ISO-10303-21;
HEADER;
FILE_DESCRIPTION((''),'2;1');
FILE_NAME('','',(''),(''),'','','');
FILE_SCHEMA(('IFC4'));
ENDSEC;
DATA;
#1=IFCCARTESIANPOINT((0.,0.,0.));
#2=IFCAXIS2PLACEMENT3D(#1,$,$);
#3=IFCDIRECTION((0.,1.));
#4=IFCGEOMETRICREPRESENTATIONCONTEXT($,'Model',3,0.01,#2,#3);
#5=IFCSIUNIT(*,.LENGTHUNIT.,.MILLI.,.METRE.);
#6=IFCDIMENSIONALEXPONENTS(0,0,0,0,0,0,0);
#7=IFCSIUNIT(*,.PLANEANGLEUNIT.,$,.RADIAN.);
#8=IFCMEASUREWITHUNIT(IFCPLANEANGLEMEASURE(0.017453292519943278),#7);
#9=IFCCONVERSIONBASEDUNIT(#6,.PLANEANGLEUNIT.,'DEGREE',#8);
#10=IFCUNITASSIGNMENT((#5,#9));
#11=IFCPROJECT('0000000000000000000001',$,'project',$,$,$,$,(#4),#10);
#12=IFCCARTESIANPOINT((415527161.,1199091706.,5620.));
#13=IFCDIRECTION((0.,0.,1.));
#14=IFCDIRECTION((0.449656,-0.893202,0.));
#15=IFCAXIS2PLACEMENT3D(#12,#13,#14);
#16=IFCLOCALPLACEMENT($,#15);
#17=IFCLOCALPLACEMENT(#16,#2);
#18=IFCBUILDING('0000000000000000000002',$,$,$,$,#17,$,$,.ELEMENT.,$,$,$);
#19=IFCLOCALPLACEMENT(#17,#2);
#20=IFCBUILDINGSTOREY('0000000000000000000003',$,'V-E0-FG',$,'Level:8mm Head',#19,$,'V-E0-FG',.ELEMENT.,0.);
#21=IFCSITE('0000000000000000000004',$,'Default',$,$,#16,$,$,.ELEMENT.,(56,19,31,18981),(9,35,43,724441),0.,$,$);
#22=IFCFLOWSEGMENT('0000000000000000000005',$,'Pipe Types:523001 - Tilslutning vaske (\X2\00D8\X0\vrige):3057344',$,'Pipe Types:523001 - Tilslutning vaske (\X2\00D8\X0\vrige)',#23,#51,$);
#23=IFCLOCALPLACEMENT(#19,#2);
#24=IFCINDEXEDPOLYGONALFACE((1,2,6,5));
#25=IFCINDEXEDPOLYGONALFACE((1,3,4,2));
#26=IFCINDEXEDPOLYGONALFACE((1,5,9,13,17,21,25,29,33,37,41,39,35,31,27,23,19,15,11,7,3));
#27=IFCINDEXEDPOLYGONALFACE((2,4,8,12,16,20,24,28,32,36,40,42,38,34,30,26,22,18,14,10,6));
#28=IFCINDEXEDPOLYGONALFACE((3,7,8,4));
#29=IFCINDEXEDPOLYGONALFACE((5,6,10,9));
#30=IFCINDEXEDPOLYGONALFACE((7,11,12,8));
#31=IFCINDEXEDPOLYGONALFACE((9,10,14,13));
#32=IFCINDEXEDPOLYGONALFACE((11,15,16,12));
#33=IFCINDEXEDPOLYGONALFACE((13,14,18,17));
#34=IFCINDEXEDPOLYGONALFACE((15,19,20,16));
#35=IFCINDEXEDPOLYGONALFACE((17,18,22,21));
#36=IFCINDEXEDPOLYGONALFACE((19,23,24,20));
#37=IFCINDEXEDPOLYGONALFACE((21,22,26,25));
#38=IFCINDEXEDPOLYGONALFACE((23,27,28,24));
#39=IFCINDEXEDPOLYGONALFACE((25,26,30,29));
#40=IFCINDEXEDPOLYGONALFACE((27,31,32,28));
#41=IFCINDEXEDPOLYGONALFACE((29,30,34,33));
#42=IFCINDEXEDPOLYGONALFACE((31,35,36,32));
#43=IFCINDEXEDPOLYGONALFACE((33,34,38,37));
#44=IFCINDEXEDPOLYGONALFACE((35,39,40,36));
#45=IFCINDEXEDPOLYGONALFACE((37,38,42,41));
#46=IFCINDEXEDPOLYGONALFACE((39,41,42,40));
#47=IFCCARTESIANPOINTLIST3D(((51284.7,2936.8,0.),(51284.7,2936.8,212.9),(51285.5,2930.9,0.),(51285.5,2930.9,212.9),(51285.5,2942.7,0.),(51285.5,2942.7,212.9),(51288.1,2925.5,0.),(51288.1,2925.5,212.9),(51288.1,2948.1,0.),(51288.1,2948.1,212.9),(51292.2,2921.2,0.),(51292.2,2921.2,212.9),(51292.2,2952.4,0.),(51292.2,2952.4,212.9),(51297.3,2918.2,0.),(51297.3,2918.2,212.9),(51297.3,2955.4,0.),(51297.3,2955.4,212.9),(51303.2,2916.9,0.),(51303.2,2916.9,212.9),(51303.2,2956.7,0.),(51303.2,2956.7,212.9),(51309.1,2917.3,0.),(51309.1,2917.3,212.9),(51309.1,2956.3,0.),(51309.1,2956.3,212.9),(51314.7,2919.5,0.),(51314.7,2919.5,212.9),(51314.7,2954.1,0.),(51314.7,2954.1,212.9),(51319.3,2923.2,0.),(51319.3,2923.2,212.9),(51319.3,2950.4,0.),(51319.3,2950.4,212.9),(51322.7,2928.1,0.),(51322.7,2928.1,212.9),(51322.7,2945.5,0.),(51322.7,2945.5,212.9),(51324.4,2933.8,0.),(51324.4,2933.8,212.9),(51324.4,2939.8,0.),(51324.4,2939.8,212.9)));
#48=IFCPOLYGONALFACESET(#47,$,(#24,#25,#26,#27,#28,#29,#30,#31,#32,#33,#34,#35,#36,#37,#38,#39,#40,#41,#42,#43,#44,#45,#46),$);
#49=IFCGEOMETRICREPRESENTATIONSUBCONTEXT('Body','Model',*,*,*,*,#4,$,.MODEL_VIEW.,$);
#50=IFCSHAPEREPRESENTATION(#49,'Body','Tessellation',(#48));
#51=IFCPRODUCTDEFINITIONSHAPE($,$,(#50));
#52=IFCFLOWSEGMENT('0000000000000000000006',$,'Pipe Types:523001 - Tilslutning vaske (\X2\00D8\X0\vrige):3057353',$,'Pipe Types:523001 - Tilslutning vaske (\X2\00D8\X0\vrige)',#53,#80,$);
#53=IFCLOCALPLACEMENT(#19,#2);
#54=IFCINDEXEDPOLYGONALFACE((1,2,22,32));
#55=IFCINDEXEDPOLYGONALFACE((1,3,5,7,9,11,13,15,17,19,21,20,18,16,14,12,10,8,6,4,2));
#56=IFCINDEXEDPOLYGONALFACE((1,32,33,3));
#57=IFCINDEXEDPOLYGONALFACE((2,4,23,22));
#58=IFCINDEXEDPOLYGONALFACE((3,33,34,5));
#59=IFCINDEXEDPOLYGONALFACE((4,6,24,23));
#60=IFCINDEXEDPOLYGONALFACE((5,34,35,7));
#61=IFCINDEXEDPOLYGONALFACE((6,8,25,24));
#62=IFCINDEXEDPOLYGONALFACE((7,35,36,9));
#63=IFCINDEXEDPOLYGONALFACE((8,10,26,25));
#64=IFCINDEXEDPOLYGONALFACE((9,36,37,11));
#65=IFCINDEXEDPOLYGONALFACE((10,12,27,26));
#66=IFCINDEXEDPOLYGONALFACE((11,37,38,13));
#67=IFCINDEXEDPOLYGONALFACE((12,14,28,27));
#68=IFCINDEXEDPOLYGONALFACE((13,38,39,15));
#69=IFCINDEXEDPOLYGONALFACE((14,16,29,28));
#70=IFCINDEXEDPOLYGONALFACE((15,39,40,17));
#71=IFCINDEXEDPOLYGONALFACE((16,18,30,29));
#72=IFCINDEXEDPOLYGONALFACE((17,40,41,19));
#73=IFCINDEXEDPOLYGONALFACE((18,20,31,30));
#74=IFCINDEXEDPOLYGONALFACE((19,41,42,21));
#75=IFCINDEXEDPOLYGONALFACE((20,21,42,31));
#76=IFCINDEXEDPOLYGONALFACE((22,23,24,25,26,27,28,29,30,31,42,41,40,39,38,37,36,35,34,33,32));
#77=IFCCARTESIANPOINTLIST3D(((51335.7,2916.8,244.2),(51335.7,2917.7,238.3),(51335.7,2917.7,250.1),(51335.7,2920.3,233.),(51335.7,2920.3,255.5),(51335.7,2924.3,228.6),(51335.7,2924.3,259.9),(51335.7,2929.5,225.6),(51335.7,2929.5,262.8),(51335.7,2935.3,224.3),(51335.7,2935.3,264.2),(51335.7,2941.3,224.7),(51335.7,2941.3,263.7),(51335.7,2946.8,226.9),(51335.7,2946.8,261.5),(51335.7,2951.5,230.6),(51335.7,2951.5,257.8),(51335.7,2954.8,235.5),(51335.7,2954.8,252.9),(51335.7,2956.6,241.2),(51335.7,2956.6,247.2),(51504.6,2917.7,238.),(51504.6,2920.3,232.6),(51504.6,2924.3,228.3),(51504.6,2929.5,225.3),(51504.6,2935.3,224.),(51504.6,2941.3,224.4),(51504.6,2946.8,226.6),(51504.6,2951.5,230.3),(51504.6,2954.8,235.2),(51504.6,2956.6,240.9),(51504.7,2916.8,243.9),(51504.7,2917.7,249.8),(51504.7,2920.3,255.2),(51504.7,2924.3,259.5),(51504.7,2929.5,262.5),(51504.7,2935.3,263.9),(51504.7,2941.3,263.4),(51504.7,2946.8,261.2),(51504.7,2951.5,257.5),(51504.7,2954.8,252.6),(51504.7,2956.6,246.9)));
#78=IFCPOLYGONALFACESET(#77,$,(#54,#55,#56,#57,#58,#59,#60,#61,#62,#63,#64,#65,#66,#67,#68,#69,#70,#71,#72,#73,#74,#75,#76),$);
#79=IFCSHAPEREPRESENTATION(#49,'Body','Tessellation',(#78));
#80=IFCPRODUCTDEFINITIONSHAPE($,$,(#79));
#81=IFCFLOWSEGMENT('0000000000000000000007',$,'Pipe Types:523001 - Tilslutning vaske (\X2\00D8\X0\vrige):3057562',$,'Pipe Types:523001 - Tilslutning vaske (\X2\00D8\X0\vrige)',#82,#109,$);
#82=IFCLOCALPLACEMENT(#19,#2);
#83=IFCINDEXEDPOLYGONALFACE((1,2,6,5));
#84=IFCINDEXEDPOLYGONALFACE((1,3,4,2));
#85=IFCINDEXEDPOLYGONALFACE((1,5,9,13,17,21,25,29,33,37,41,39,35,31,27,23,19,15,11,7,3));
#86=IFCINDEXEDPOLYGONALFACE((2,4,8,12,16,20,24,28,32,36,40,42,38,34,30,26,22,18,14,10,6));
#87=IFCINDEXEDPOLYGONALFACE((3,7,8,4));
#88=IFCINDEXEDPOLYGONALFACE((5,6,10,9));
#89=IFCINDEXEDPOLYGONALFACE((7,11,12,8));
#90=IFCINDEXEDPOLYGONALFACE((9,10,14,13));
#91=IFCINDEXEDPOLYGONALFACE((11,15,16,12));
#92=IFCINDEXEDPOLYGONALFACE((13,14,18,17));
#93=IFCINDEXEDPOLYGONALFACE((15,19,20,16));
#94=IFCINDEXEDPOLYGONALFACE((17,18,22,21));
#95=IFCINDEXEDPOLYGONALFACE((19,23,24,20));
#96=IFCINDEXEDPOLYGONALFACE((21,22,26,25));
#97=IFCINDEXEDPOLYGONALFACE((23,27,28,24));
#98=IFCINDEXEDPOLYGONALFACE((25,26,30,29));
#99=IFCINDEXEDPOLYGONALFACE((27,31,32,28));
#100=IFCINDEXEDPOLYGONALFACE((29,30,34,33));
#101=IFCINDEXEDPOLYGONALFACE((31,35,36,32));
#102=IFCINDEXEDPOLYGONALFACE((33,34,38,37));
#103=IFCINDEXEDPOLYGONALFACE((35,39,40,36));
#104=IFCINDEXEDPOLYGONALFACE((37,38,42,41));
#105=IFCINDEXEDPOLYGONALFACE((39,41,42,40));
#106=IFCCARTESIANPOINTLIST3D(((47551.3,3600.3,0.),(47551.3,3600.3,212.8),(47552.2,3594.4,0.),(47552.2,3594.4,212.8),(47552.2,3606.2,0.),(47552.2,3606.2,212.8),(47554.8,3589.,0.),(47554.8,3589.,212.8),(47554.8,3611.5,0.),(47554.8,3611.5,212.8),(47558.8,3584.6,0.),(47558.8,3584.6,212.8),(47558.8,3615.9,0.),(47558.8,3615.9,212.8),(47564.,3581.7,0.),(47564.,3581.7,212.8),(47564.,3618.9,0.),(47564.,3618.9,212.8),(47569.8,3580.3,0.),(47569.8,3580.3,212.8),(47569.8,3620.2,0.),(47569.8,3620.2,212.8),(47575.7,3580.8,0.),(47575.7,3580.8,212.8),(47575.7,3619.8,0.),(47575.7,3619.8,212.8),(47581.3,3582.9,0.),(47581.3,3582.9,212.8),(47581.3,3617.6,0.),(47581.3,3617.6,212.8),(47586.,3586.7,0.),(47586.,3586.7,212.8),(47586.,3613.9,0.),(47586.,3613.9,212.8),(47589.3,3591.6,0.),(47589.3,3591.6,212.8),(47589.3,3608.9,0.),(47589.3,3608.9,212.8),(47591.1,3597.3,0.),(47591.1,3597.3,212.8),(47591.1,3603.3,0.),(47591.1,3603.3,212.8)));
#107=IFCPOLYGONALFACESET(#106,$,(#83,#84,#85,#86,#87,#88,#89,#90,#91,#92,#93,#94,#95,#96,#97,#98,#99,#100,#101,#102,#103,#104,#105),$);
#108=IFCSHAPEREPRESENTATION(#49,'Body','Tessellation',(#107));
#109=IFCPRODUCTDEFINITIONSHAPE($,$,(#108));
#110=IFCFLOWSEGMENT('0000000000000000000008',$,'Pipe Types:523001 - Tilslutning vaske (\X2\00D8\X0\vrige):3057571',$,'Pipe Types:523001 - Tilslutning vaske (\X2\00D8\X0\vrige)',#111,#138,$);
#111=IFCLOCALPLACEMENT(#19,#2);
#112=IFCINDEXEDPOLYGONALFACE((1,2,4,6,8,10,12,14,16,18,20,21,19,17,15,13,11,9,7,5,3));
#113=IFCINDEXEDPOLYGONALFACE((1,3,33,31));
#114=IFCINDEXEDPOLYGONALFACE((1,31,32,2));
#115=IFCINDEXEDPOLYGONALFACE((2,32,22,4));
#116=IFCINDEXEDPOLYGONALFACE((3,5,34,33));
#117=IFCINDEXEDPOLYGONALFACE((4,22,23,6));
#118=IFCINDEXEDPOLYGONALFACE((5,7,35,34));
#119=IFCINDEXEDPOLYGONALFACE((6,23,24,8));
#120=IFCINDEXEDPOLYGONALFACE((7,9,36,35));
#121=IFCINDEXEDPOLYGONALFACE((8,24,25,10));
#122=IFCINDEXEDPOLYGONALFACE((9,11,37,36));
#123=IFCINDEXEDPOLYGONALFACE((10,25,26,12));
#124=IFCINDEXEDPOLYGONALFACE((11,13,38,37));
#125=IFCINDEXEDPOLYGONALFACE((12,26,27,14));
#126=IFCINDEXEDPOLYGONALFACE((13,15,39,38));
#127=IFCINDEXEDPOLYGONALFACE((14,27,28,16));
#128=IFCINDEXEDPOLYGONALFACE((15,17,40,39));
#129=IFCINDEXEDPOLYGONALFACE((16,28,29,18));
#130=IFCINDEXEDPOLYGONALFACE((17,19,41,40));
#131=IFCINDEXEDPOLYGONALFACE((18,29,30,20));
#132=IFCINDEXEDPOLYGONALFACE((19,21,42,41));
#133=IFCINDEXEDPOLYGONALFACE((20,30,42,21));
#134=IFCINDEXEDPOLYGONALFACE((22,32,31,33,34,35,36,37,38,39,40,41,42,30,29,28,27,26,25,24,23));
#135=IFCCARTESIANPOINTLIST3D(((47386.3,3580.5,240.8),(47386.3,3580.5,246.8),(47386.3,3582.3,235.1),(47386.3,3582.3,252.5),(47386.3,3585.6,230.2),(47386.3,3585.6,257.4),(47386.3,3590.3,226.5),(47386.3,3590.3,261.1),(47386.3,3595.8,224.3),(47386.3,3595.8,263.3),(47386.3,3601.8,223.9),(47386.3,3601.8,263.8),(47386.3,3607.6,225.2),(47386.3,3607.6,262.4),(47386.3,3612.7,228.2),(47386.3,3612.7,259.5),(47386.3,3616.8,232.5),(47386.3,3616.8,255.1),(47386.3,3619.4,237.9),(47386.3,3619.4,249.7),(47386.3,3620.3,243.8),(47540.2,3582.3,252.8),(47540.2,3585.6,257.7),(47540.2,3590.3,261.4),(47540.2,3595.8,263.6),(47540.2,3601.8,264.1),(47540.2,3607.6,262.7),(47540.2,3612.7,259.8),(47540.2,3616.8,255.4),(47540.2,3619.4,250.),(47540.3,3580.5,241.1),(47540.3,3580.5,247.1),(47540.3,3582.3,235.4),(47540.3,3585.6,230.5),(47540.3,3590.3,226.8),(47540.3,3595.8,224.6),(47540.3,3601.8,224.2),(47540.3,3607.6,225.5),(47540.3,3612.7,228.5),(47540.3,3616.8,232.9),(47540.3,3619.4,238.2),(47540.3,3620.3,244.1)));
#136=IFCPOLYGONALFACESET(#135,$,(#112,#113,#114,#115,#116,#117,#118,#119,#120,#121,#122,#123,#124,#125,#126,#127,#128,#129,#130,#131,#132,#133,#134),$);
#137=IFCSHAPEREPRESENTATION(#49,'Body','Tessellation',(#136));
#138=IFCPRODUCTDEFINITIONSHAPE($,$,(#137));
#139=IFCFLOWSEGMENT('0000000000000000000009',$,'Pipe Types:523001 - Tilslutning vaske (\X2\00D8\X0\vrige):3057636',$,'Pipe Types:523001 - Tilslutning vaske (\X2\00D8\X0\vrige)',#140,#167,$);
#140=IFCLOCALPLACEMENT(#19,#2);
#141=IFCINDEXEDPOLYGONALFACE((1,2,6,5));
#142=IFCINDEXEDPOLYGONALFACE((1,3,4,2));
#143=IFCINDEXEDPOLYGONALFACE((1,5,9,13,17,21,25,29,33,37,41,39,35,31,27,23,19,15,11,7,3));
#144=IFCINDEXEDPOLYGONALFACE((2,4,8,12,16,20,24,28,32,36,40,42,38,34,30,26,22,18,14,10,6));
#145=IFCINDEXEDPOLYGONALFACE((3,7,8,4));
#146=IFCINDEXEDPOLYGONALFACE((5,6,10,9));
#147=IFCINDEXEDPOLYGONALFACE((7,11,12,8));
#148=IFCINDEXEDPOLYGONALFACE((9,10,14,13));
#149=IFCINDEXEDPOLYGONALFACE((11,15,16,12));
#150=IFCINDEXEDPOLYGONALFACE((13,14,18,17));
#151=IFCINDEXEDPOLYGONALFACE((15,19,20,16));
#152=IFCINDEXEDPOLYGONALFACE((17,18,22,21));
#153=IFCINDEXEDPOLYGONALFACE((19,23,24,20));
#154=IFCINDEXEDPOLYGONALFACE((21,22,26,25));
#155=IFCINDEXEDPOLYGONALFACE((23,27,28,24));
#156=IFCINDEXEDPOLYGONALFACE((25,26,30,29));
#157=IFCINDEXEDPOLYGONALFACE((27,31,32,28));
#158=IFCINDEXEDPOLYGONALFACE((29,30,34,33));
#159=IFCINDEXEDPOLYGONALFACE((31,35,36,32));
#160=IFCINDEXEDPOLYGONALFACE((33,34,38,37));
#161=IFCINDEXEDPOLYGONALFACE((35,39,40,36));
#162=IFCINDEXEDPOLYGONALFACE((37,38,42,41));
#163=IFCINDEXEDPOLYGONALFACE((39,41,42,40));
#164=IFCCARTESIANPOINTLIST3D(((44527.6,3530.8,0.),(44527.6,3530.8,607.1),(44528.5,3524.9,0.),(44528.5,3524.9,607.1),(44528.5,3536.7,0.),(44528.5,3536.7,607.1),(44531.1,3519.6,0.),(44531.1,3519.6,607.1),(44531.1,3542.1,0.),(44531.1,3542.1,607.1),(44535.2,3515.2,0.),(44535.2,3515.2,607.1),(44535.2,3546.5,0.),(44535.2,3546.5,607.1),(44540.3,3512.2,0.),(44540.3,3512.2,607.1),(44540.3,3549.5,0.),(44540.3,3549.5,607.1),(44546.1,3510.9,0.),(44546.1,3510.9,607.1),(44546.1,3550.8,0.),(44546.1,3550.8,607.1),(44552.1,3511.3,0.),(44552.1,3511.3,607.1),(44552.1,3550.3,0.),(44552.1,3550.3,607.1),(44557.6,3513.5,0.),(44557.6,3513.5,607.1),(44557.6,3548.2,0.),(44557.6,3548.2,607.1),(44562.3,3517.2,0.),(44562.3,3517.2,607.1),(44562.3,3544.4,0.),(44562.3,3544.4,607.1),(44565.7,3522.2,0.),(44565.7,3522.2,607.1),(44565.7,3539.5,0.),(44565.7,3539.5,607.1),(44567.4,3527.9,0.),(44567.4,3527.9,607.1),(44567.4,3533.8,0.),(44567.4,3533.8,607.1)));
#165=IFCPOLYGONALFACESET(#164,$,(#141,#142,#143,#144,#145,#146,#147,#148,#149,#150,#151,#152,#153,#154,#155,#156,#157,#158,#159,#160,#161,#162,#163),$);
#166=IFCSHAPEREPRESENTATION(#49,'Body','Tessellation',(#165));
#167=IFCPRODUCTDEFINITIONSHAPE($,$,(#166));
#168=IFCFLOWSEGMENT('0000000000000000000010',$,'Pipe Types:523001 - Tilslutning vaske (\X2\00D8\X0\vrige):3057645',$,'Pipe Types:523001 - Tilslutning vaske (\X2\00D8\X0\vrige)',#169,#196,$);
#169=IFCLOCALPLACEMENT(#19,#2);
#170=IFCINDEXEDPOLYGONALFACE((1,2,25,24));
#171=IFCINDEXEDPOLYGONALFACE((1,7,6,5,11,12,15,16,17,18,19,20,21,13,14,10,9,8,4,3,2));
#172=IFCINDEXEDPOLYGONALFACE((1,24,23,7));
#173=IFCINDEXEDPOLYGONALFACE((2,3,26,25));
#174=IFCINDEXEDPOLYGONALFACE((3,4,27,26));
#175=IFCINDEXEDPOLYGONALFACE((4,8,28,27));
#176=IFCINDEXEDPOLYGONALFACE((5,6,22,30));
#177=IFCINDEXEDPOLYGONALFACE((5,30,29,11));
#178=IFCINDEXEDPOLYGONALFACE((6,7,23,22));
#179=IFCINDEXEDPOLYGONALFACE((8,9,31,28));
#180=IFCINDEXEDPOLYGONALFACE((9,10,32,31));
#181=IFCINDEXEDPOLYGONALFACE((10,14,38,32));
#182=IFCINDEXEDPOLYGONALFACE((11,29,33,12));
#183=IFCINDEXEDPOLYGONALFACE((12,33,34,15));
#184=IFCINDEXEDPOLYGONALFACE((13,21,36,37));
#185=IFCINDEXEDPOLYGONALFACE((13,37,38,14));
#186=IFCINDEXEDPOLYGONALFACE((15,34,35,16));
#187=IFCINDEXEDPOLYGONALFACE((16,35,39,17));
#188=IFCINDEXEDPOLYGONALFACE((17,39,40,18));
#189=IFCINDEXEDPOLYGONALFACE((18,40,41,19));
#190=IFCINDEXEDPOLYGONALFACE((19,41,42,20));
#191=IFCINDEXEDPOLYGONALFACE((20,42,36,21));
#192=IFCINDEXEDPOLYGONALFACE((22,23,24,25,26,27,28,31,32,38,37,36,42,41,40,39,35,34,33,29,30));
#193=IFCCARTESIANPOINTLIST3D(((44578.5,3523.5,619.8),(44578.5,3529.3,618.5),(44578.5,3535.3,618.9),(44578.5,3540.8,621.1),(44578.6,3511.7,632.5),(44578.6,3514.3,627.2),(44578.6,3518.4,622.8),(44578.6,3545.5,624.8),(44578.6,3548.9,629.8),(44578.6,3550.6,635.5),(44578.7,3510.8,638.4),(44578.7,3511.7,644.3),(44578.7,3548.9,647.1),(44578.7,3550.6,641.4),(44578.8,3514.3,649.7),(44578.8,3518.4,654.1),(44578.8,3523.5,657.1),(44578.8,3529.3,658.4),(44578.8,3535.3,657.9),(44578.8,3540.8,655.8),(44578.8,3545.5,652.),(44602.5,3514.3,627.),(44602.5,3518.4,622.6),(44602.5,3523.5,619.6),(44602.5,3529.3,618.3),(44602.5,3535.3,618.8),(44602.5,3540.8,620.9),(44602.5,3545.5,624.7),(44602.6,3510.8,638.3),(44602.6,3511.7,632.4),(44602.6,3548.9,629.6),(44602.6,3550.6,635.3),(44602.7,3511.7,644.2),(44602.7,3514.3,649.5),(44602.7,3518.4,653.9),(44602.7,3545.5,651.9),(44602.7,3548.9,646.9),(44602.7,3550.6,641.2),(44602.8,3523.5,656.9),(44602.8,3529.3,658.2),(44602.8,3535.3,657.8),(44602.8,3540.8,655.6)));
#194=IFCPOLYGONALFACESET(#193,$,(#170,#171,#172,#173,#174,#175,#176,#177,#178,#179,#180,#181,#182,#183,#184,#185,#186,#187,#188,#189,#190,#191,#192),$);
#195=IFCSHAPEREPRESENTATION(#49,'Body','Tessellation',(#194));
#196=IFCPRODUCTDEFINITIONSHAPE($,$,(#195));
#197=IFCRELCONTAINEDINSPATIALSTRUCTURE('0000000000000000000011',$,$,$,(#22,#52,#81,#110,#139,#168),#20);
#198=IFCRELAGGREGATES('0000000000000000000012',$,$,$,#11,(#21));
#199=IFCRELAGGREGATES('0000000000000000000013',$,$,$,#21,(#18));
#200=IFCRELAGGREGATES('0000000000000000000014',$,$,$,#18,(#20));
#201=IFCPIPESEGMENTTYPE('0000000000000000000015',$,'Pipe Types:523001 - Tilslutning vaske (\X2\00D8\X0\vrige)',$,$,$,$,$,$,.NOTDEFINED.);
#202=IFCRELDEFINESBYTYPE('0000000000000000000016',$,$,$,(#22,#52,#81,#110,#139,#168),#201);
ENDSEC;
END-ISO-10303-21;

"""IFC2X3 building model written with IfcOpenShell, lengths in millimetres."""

from ifc_helpers import new_model, entity, si_unit, converted_unit, direction, frame, frame_2d, origin, origin_2d_with_axis, place, context, subcontext, project, spatial, circle, extrude, type_object, element, save


model = new_model("IFC2X3")

# Units and contexts
model_context = context("Model", 3, precision=0.01, world=origin(), true_north=direction((0.0, 1.0)))
body_context = subcontext(model_context, "Body", "Model", "MODEL_VIEW")
ifc_project = project(units=[si_unit("LENGTHUNIT", "METRE", prefix="MILLI"), converted_unit("PLANEANGLEUNIT", "DEGREE", entity("IfcPlaneAngleMeasure", 0.017453292519943278), si_unit("PLANEANGLEUNIT", "RADIAN"), dimensions=[0, 0, 0, 0, 0, 0, 0])], contexts=[model_context])

# Site, building, storey
site_placement = place(None, frame((415527161.0, 1199091706.0, 5620.0), z_axis=(0.0, 0.0, 1.0), x_axis=(0.449656, -0.893202, 0.0)))
site = spatial("IfcSite", under=ifc_project, at=site_placement, Name="Default", CompositionType="ELEMENT", RefLatitude=(56, 19, 31, 18981), RefLongitude=(9, 35, 43, 724441), RefElevation=0.0)
building_placement = place(site_placement, origin())
building = spatial("IfcBuilding", under=site, at=building_placement, CompositionType="ELEMENT")
storey_placement = place(building_placement, origin())
storey = spatial("IfcBuildingStorey", under=building, at=storey_placement, Name="V-E0-FG", ObjectType="Level:8mm Head", LongName="V-E0-FG", CompositionType="ELEMENT", Elevation=0.0)

# Flow segments
pipe_segment_type_1 = type_object("IfcPipeSegmentType", Name="Pipe Types:523001 - Tilslutning vaske (Øvrige)", PredefinedType="NOTDEFINED")
flow_segment_1_placement = place(storey_placement, origin())
element("IfcFlowSegment", 1, at=flow_segment_1_placement, inside=storey, type_object=pipe_segment_type_1, Name="Pipe Types:523001 - Tilslutning vaske (Øvrige):3057344", ObjectType="Pipe Types:523001 - Tilslutning vaske (Øvrige)", context=body_context, shape_type="SweptSolid", body=[
    extrude(circle(Radius=20.0, at=origin_2d_with_axis()), frame((51304.7, 2936.8, 0.0), z_axis=(0.0, 0.0, 1.0), x_axis=(-1.0, 0.0, 0.0)), (0.0, 0.0, 1.0), 212.9),
])
flow_segment_2_placement = place(storey_placement, origin())
element("IfcFlowSegment", 2, at=flow_segment_2_placement, inside=storey, type_object=pipe_segment_type_1, Name="Pipe Types:523001 - Tilslutning vaske (Øvrige):3057353", ObjectType="Pipe Types:523001 - Tilslutning vaske (Øvrige)", context=body_context, shape_type="SweptSolid", body=[
    extrude(circle(Radius=20.0, at=frame_2d((0.0, 0.0), x_axis=(1.0, 0.0))), frame((51335.7, 2936.8, 244.2), z_axis=(0.999998, 0.0, -0.001837), x_axis=(0.0, -1.0, 0.0)), (0.0, 0.0, 1.0), 169.0),
])
flow_segment_3_placement = place(storey_placement, origin())
element("IfcFlowSegment", 3, at=flow_segment_3_placement, inside=storey, type_object=pipe_segment_type_1, Name="Pipe Types:523001 - Tilslutning vaske (Øvrige):3057562", ObjectType="Pipe Types:523001 - Tilslutning vaske (Øvrige)", context=body_context, shape_type="SweptSolid", body=[
    extrude(circle(Radius=20.0, at=origin_2d_with_axis()), frame((47571.3, 3600.3, 0.0), z_axis=(0.0, 0.0, 1.0), x_axis=(-1.0, 0.0, 0.0)), (0.0, 0.0, 1.0), 212.8),
])
flow_segment_4_placement = place(storey_placement, origin())
element("IfcFlowSegment", 4, at=flow_segment_4_placement, inside=storey, type_object=pipe_segment_type_1, Name="Pipe Types:523001 - Tilslutning vaske (Øvrige):3057571", ObjectType="Pipe Types:523001 - Tilslutning vaske (Øvrige)", context=body_context, shape_type="SweptSolid", body=[
    extrude(circle(Radius=20.0, at=origin_2d_with_axis()), frame((47386.3, 3600.3, 243.8), z_axis=(0.999998, 0.0, 0.002016), x_axis=(0.0, 1.0, 0.0)), (0.0, 0.0, 1.0), 154.0),
])
flow_segment_5_placement = place(storey_placement, origin())
element("IfcFlowSegment", 5, at=flow_segment_5_placement, inside=storey, type_object=pipe_segment_type_1, Name="Pipe Types:523001 - Tilslutning vaske (Øvrige):3057636", ObjectType="Pipe Types:523001 - Tilslutning vaske (Øvrige)", context=body_context, shape_type="SweptSolid", body=[
    extrude(circle(Radius=20.0, at=origin_2d_with_axis()), frame((44547.6, 3530.8, 0.0), z_axis=(0.0, 0.0, 1.0), x_axis=(-1.0, 0.0, 0.0)), (0.0, 0.0, 1.0), 607.1),
])
flow_segment_6_placement = place(storey_placement, origin())
element("IfcFlowSegment", 6, at=flow_segment_6_placement, inside=storey, type_object=pipe_segment_type_1, Name="Pipe Types:523001 - Tilslutning vaske (Øvrige):3057645", ObjectType="Pipe Types:523001 - Tilslutning vaske (Øvrige)", context=body_context, shape_type="SweptSolid", body=[
    extrude(circle(Radius=20.0, at=origin_2d_with_axis()), frame((44602.6, 3530.8, 638.3), z_axis=(-0.999972, 0.0, 0.00744), x_axis=(0.0, -1.0, 0.0)), (0.0, 0.0, 1.0), 24.0),
])

save(model, "model.ifc")
